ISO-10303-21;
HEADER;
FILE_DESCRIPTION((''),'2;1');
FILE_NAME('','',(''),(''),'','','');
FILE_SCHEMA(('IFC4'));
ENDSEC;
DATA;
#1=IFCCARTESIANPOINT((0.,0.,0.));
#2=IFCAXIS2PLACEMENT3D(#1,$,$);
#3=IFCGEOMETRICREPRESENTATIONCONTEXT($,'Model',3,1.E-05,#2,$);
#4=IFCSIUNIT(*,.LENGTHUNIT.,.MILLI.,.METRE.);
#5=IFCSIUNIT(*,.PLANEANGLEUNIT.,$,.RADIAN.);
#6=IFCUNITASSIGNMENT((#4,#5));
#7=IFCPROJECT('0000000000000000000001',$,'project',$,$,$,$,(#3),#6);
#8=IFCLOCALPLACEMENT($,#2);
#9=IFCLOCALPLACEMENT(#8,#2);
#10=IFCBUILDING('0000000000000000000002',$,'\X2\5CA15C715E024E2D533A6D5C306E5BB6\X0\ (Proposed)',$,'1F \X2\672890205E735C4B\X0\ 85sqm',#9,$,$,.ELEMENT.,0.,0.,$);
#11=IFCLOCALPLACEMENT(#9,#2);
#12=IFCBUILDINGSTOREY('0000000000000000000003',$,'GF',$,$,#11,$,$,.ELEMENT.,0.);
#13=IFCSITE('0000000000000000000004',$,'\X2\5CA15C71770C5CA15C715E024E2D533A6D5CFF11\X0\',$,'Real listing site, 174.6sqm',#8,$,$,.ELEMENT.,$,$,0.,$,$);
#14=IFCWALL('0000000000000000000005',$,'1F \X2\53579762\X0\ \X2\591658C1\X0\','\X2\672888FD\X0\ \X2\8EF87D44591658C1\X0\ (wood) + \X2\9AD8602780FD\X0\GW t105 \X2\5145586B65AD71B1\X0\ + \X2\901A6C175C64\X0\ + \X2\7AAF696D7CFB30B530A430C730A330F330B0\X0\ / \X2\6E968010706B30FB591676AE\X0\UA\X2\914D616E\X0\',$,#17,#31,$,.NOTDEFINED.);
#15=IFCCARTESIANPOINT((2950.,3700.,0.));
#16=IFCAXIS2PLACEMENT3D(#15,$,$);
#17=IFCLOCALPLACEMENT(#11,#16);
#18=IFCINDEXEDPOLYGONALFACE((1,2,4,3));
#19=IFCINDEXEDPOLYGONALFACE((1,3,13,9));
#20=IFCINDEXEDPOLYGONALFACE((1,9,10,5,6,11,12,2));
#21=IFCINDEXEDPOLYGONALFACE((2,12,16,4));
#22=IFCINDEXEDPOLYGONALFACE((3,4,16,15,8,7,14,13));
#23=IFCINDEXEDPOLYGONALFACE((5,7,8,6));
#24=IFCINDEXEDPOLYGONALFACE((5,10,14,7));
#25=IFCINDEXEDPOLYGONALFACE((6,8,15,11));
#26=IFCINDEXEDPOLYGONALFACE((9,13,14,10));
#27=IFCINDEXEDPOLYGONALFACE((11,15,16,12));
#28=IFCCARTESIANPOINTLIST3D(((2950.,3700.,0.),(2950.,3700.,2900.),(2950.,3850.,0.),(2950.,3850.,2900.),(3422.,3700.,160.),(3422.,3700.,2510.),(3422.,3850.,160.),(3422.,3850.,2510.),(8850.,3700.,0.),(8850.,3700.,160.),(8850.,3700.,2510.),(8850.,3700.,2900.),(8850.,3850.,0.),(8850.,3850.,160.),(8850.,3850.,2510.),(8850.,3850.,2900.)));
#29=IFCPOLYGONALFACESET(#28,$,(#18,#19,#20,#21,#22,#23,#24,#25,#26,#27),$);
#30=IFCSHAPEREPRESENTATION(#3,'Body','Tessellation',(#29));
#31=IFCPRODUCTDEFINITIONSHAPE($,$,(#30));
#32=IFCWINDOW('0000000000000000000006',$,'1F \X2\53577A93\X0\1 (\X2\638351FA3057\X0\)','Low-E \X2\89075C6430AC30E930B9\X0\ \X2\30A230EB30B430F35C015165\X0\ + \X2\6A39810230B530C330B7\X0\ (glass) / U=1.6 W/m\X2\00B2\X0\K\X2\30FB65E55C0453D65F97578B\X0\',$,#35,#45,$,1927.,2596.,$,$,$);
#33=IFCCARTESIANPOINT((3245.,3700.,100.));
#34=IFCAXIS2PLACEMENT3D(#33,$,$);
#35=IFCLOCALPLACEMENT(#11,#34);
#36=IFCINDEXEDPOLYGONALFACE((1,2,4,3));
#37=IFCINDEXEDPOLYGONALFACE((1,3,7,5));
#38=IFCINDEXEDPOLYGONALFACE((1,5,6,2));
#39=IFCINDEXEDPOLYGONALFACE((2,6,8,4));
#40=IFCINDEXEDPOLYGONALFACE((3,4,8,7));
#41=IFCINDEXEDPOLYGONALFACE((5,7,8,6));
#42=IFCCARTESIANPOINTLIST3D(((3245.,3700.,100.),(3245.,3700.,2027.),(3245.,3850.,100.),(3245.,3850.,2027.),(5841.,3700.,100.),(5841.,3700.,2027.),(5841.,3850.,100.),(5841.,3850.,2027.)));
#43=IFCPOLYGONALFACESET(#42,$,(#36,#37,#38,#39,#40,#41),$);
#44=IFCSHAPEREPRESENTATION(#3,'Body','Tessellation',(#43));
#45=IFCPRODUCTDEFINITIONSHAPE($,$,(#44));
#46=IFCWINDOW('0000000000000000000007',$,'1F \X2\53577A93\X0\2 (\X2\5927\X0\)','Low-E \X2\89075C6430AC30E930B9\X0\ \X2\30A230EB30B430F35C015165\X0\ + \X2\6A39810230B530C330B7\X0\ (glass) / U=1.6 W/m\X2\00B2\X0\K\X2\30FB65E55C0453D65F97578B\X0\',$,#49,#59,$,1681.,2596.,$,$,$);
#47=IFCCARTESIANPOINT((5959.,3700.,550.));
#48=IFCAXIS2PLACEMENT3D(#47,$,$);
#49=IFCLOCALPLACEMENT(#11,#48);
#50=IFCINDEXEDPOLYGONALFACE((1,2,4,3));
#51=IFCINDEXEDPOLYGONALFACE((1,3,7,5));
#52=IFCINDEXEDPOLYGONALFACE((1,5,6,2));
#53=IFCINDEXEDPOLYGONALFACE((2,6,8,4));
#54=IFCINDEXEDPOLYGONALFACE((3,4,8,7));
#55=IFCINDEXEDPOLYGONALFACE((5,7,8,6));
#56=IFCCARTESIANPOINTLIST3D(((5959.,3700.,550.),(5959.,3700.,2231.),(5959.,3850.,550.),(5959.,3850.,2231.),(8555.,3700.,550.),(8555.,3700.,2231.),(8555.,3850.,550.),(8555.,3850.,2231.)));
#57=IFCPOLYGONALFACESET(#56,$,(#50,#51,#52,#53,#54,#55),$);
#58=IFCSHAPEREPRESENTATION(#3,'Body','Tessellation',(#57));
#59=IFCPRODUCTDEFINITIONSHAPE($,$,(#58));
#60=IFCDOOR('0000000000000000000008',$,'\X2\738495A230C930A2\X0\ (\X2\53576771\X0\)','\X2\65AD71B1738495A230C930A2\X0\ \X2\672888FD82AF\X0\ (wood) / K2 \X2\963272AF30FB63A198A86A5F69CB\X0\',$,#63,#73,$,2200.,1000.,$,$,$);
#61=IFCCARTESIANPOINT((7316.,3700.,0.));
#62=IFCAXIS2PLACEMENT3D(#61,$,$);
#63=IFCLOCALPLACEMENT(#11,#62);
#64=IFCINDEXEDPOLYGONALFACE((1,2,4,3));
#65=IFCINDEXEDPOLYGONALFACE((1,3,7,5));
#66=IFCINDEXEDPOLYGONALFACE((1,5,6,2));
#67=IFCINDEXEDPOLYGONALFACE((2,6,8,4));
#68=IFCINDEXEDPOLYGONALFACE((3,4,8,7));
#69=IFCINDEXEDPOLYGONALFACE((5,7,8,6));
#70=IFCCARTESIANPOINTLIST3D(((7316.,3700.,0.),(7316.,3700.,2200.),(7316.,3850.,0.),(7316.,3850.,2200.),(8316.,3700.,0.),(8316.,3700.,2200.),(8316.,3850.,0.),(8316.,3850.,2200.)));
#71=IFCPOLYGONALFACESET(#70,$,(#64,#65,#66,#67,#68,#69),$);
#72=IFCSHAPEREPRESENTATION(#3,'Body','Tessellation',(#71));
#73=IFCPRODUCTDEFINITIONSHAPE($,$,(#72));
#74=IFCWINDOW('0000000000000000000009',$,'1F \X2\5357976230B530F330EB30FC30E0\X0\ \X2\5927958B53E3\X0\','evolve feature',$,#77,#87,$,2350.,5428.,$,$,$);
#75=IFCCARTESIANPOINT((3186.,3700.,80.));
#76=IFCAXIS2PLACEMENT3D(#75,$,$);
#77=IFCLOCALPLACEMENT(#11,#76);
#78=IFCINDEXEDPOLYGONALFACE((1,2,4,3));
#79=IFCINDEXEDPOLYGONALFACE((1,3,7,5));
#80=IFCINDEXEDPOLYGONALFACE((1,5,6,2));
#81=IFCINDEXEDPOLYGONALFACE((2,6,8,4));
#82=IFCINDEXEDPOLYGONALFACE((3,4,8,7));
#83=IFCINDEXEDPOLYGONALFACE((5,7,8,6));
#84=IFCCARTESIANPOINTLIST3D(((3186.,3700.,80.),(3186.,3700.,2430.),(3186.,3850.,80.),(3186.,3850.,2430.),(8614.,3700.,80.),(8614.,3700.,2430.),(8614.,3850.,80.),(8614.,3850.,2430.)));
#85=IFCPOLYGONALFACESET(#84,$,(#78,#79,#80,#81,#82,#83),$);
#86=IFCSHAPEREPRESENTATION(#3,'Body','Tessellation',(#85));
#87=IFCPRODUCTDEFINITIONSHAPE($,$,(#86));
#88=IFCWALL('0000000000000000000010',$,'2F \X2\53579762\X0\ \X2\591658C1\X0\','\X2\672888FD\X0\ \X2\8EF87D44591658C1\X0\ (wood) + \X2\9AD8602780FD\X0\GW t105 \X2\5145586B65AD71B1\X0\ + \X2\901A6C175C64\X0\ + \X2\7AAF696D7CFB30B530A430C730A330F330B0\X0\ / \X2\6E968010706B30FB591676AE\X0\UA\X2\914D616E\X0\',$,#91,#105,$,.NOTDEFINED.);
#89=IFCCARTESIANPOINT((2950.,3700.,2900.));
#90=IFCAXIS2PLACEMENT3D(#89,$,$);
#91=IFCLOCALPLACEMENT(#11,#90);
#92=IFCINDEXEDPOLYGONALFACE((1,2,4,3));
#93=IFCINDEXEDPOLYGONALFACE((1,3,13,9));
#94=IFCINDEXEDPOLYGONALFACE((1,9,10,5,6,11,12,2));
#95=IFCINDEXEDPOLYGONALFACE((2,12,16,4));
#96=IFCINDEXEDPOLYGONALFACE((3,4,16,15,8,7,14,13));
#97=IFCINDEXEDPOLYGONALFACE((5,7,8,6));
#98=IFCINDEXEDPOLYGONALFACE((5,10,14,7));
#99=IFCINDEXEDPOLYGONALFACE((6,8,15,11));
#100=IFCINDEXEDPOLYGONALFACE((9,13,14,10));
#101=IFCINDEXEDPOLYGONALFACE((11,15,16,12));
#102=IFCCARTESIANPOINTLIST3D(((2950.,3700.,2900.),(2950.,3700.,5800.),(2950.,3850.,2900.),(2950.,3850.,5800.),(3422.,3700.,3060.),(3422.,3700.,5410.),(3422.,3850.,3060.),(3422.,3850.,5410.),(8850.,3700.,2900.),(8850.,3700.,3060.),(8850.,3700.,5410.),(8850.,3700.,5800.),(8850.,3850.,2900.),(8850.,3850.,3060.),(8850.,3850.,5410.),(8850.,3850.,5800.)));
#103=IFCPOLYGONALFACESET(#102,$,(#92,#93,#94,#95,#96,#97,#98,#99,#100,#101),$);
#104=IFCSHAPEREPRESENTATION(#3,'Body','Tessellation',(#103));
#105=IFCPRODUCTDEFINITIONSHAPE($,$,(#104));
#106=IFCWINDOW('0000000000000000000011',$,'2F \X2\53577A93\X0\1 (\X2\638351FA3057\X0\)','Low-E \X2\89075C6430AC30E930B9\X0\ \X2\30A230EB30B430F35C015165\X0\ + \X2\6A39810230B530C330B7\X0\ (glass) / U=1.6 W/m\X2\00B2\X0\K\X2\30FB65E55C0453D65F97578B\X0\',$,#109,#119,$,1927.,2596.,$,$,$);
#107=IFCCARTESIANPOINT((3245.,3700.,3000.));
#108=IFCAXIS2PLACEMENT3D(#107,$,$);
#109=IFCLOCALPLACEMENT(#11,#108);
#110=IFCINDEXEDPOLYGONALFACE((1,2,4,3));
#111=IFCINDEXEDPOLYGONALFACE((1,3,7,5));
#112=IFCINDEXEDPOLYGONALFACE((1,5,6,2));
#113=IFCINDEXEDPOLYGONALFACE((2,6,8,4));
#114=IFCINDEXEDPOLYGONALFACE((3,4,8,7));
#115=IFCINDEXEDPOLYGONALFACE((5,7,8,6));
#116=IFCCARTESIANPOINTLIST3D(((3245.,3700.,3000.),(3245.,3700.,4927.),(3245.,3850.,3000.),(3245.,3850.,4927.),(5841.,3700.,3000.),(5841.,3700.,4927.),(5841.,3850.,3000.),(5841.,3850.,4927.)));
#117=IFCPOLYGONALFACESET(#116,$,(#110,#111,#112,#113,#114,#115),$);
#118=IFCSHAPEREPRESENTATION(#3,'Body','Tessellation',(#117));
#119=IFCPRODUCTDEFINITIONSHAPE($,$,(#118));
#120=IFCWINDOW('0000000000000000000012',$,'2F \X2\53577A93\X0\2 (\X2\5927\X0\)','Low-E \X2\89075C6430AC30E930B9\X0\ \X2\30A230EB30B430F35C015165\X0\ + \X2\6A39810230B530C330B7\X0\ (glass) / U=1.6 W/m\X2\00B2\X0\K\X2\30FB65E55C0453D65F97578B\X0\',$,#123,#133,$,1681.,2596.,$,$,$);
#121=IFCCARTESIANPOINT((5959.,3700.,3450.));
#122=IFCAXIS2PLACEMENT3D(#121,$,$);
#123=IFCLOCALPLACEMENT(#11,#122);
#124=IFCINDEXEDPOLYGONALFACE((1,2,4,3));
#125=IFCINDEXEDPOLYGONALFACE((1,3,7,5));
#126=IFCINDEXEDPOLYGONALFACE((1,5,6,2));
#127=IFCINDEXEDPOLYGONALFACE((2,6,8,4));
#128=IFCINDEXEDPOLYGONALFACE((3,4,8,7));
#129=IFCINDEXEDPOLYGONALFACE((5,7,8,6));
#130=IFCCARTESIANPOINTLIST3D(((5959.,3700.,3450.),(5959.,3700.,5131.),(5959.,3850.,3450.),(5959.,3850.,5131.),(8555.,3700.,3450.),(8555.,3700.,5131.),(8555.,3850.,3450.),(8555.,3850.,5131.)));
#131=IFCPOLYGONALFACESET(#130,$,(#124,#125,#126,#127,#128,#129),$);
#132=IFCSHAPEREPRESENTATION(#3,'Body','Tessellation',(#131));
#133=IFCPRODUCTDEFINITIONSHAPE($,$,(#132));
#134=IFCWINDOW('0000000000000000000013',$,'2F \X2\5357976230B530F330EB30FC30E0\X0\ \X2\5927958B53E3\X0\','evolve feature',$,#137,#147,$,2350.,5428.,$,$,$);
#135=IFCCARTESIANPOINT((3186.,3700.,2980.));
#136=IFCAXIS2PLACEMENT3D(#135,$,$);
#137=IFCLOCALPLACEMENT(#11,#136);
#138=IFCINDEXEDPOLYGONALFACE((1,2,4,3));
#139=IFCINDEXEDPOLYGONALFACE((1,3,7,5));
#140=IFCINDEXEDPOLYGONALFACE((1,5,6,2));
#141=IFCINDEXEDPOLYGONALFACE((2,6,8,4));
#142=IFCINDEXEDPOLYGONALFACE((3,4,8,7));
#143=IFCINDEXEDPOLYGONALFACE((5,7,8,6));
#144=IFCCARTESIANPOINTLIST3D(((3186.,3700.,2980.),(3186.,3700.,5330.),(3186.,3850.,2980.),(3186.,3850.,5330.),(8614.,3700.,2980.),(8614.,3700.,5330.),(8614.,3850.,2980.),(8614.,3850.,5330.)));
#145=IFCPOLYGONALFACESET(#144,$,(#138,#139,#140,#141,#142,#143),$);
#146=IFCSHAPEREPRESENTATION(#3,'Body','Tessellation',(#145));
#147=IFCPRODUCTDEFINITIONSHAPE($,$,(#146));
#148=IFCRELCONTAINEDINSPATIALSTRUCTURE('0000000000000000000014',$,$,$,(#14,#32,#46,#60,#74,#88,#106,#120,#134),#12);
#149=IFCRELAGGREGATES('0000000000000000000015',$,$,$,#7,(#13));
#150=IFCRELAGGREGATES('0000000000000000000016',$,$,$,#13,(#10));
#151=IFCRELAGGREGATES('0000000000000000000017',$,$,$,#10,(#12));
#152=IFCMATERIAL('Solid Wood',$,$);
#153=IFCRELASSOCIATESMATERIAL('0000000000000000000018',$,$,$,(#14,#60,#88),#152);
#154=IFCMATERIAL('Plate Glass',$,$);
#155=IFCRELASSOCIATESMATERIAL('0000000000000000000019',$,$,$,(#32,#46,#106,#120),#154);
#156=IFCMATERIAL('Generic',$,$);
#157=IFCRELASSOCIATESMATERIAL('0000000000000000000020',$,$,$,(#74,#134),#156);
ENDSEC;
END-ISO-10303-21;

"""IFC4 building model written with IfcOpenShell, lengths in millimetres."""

from ifc_helpers import new_model, si_unit, frame, frame_2d, origin, place, context, project, spatial, rectangle, extrude, material, element, fill, save


model = new_model("IFC4")

# Units and contexts
model_context = context("Model", 3, precision=1e-05, world=origin())
ifc_project = project(units=[si_unit("LENGTHUNIT", "METRE", prefix="MILLI"), si_unit("PLANEANGLEUNIT", "RADIAN")], contexts=[model_context])

# Site, building, storey
site_placement = place(None, origin())
site = spatial("IfcSite", under=ifc_project, at=site_placement, Name="岡山県岡山市中区浜１", ObjectType="Real listing site, 174.6sqm", CompositionType="ELEMENT", RefElevation=0.0)
building_placement = place(site_placement, origin())
building = spatial("IfcBuilding", under=site, at=building_placement, Name="岡山市中区浜の家 (Proposed)", ObjectType="1F 木造平屋 85sqm", CompositionType="ELEMENT", ElevationOfRefHeight=0.0, ElevationOfTerrain=0.0)
storey_placement = place(building_placement, origin())
storey = spatial("IfcBuildingStorey", under=building, at=storey_placement, Name="GF", CompositionType="ELEMENT", Elevation=0.0)

# Shared definitions
ifc_material_1 = material(Name="Solid Wood")
ifc_material_2 = material(Name="Generic")

# Wall, openings, windows, door
wall_1_placement = place(storey_placement, frame((2950.0, 3700.0, 0.0)))
wall_1 = element("IfcWall", 1, at=wall_1_placement, inside=storey, material=ifc_material_1, Name="1F 南面 外壁", Description="木製 軸組外壁 (wood) + 高性能GW t105 充填断熱 + 通気層 + 窯業系サイディング / 準耐火・外皮UA配慮", PredefinedType="NOTDEFINED", context=model_context, shape_type="SweptSolid", body=[
    extrude(rectangle(XDim=5900.0, YDim=150.0, at=frame_2d((2950.0, 75.0))), frame((2950.0, 3700.0, 0.0)), (0.0, 0.0, 1.0), 2900.0),
])
opening_1_placement = place(storey_placement, frame((3245.0, 3700.0, 100.0)))
opening_1 = element("IfcOpeningElement", 2, at=opening_1_placement, cuts=wall_1, PredefinedType="NOTDEFINED", context=model_context, shape_type="SweptSolid", body=[
    extrude(rectangle(XDim=2596.0, YDim=150.0, at=frame_2d((1298.0, 75.0))), frame((3245.0, 3700.0, 100.0)), (0.0, 0.0, 1.0), 1927.0),
])
opening_2_placement = place(storey_placement, frame((5959.0, 3700.0, 550.0)))
opening_2 = element("IfcOpeningElement", 3, at=opening_2_placement, cuts=wall_1, PredefinedType="NOTDEFINED", context=model_context, shape_type="SweptSolid", body=[
    extrude(rectangle(XDim=2596.0, YDim=150.0, at=frame_2d((1298.0, 75.0))), frame((5959.0, 3700.0, 550.0)), (0.0, 0.0, 1.0), 1681.0),
])
opening_3_placement = place(storey_placement, frame((7316.0, 3700.0, 0.0)))
opening_3 = element("IfcOpeningElement", 4, at=opening_3_placement, cuts=wall_1, PredefinedType="NOTDEFINED", context=model_context, shape_type="SweptSolid", body=[
    extrude(rectangle(XDim=1000.0, YDim=150.0, at=frame_2d((500.0, 75.0))), frame((7316.0, 3700.0, 0.0)), (0.0, 0.0, 1.0), 2200.0),
])
opening_4_placement = place(storey_placement, frame((3186.0, 3700.0, 80.0)))
opening_4 = element("IfcOpeningElement", 5, at=opening_4_placement, cuts=wall_1, PredefinedType="NOTDEFINED", context=model_context, shape_type="SweptSolid", body=[
    extrude(rectangle(XDim=5428.0, YDim=150.0, at=frame_2d((2714.0, 75.0))), frame((3186.0, 3700.0, 80.0)), (0.0, 0.0, 1.0), 2350.0),
])
ifc_material_3 = material(Name="Plate Glass")
window_1_placement = place(storey_placement, frame((3245.0, 3700.0, 100.0)))
window_1 = element("IfcWindow", 6, at=window_1_placement, inside=storey, material=ifc_material_3, Name="1F 南窓1 (掃出し)", Description="Low-E 複層ガラス アルゴン封入 + 樹脂サッシ (glass) / U=1.6 W/m²K・日射取得型", OverallHeight=1927.0, OverallWidth=2596.0, context=model_context, shape_type="SweptSolid", body=[
    extrude(rectangle(XDim=2596.0, YDim=150.0, at=frame_2d((1298.0, 75.0))), frame((3245.0, 3700.0, 100.0)), (0.0, 0.0, 1.0), 1927.0),
])
fill(opening_1, window_1)
window_2_placement = place(storey_placement, frame((5959.0, 3700.0, 550.0)))
window_2 = element("IfcWindow", 7, at=window_2_placement, inside=storey, material=ifc_material_3, Name="1F 南窓2 (大)", Description="Low-E 複層ガラス アルゴン封入 + 樹脂サッシ (glass) / U=1.6 W/m²K・日射取得型", OverallHeight=1681.0, OverallWidth=2596.0, context=model_context, shape_type="SweptSolid", body=[
    extrude(rectangle(XDim=2596.0, YDim=150.0, at=frame_2d((1298.0, 75.0))), frame((5959.0, 3700.0, 550.0)), (0.0, 0.0, 1.0), 1681.0),
])
fill(opening_2, window_2)
door_placement = place(storey_placement, frame((7316.0, 3700.0, 0.0)))
door = element("IfcDoor", 8, at=door_placement, inside=storey, material=ifc_material_1, Name="玄関ドア (南東)", Description="断熱玄関ドア 木製芯 (wood) / K2 防犯・採風機構", OverallHeight=2200.0, OverallWidth=1000.0, context=model_context, shape_type="SweptSolid", body=[
    extrude(rectangle(XDim=1000.0, YDim=150.0, at=frame_2d((500.0, 75.0))), frame((7316.0, 3700.0, 0.0)), (0.0, 0.0, 1.0), 2200.0),
])
fill(opening_3, door)
window_3_placement = place(storey_placement, frame((3186.0, 3700.0, 80.0)))
window_3 = element("IfcWindow", 9, at=window_3_placement, inside=storey, material=ifc_material_2, Name="1F 南面サンルーム 大開口", Description="evolve feature", OverallHeight=2350.0, OverallWidth=5428.0, context=model_context, shape_type="SweptSolid", body=[
    extrude(rectangle(XDim=5428.0, YDim=150.0, at=frame_2d((2714.0, 75.0))), frame((3186.0, 3700.0, 80.0)), (0.0, 0.0, 1.0), 2350.0),
])
fill(opening_4, window_3)

# Wall, openings, windows
wall_2_placement = place(storey_placement, frame((2950.0, 3700.0, 2900.0)))
wall_2 = element("IfcWall", 10, at=wall_2_placement, inside=storey, material=ifc_material_1, Name="2F 南面 外壁", Description="木製 軸組外壁 (wood) + 高性能GW t105 充填断熱 + 通気層 + 窯業系サイディング / 準耐火・外皮UA配慮", PredefinedType="NOTDEFINED", context=model_context, shape_type="SweptSolid", body=[
    extrude(rectangle(XDim=5900.0, YDim=150.0, at=frame_2d((2950.0, 75.0))), frame((2950.0, 3700.0, 2900.0)), (0.0, 0.0, 1.0), 2900.0),
])
opening_5_placement = place(storey_placement, frame((3245.0, 3700.0, 3000.0)))
opening_5 = element("IfcOpeningElement", 11, at=opening_5_placement, cuts=wall_2, PredefinedType="NOTDEFINED", context=model_context, shape_type="SweptSolid", body=[
    extrude(rectangle(XDim=2596.0, YDim=150.0, at=frame_2d((1298.0, 75.0))), frame((3245.0, 3700.0, 3000.0)), (0.0, 0.0, 1.0), 1927.0),
])
opening_6_placement = place(storey_placement, frame((5959.0, 3700.0, 3450.0)))
opening_6 = element("IfcOpeningElement", 12, at=opening_6_placement, cuts=wall_2, PredefinedType="NOTDEFINED", context=model_context, shape_type="SweptSolid", body=[
    extrude(rectangle(XDim=2596.0, YDim=150.0, at=frame_2d((1298.0, 75.0))), frame((5959.0, 3700.0, 3450.0)), (0.0, 0.0, 1.0), 1681.0),
])
opening_7_placement = place(storey_placement, frame((3186.0, 3700.0, 2980.0)))
opening_7 = element("IfcOpeningElement", 13, at=opening_7_placement, cuts=wall_2, PredefinedType="NOTDEFINED", context=model_context, shape_type="SweptSolid", body=[
    extrude(rectangle(XDim=5428.0, YDim=150.0, at=frame_2d((2714.0, 75.0))), frame((3186.0, 3700.0, 2980.0)), (0.0, 0.0, 1.0), 2350.0),
])
window_4_placement = place(storey_placement, frame((3245.0, 3700.0, 3000.0)))
window_4 = element("IfcWindow", 14, at=window_4_placement, inside=storey, material=ifc_material_3, Name="2F 南窓1 (掃出し)", Description="Low-E 複層ガラス アルゴン封入 + 樹脂サッシ (glass) / U=1.6 W/m²K・日射取得型", OverallHeight=1927.0, OverallWidth=2596.0, context=model_context, shape_type="SweptSolid", body=[
    extrude(rectangle(XDim=2596.0, YDim=150.0, at=frame_2d((1298.0, 75.0))), frame((3245.0, 3700.0, 3000.0)), (0.0, 0.0, 1.0), 1927.0),
])
fill(opening_5, window_4)
window_5_placement = place(storey_placement, frame((5959.0, 3700.0, 3450.0)))
window_5 = element("IfcWindow", 15, at=window_5_placement, inside=storey, material=ifc_material_3, Name="2F 南窓2 (大)", Description="Low-E 複層ガラス アルゴン封入 + 樹脂サッシ (glass) / U=1.6 W/m²K・日射取得型", OverallHeight=1681.0, OverallWidth=2596.0, context=model_context, shape_type="SweptSolid", body=[
    extrude(rectangle(XDim=2596.0, YDim=150.0, at=frame_2d((1298.0, 75.0))), frame((5959.0, 3700.0, 3450.0)), (0.0, 0.0, 1.0), 1681.0),
])
fill(opening_6, window_5)
window_6_placement = place(storey_placement, frame((3186.0, 3700.0, 2980.0)))
window_6 = element("IfcWindow", 16, at=window_6_placement, inside=storey, material=ifc_material_2, Name="2F 南面サンルーム 大開口", Description="evolve feature", OverallHeight=2350.0, OverallWidth=5428.0, context=model_context, shape_type="SweptSolid", body=[
    extrude(rectangle(XDim=5428.0, YDim=150.0, at=frame_2d((2714.0, 75.0))), frame((3186.0, 3700.0, 2980.0)), (0.0, 0.0, 1.0), 2350.0),
])
fill(opening_7, window_6)

save(model, "model.ifc")
